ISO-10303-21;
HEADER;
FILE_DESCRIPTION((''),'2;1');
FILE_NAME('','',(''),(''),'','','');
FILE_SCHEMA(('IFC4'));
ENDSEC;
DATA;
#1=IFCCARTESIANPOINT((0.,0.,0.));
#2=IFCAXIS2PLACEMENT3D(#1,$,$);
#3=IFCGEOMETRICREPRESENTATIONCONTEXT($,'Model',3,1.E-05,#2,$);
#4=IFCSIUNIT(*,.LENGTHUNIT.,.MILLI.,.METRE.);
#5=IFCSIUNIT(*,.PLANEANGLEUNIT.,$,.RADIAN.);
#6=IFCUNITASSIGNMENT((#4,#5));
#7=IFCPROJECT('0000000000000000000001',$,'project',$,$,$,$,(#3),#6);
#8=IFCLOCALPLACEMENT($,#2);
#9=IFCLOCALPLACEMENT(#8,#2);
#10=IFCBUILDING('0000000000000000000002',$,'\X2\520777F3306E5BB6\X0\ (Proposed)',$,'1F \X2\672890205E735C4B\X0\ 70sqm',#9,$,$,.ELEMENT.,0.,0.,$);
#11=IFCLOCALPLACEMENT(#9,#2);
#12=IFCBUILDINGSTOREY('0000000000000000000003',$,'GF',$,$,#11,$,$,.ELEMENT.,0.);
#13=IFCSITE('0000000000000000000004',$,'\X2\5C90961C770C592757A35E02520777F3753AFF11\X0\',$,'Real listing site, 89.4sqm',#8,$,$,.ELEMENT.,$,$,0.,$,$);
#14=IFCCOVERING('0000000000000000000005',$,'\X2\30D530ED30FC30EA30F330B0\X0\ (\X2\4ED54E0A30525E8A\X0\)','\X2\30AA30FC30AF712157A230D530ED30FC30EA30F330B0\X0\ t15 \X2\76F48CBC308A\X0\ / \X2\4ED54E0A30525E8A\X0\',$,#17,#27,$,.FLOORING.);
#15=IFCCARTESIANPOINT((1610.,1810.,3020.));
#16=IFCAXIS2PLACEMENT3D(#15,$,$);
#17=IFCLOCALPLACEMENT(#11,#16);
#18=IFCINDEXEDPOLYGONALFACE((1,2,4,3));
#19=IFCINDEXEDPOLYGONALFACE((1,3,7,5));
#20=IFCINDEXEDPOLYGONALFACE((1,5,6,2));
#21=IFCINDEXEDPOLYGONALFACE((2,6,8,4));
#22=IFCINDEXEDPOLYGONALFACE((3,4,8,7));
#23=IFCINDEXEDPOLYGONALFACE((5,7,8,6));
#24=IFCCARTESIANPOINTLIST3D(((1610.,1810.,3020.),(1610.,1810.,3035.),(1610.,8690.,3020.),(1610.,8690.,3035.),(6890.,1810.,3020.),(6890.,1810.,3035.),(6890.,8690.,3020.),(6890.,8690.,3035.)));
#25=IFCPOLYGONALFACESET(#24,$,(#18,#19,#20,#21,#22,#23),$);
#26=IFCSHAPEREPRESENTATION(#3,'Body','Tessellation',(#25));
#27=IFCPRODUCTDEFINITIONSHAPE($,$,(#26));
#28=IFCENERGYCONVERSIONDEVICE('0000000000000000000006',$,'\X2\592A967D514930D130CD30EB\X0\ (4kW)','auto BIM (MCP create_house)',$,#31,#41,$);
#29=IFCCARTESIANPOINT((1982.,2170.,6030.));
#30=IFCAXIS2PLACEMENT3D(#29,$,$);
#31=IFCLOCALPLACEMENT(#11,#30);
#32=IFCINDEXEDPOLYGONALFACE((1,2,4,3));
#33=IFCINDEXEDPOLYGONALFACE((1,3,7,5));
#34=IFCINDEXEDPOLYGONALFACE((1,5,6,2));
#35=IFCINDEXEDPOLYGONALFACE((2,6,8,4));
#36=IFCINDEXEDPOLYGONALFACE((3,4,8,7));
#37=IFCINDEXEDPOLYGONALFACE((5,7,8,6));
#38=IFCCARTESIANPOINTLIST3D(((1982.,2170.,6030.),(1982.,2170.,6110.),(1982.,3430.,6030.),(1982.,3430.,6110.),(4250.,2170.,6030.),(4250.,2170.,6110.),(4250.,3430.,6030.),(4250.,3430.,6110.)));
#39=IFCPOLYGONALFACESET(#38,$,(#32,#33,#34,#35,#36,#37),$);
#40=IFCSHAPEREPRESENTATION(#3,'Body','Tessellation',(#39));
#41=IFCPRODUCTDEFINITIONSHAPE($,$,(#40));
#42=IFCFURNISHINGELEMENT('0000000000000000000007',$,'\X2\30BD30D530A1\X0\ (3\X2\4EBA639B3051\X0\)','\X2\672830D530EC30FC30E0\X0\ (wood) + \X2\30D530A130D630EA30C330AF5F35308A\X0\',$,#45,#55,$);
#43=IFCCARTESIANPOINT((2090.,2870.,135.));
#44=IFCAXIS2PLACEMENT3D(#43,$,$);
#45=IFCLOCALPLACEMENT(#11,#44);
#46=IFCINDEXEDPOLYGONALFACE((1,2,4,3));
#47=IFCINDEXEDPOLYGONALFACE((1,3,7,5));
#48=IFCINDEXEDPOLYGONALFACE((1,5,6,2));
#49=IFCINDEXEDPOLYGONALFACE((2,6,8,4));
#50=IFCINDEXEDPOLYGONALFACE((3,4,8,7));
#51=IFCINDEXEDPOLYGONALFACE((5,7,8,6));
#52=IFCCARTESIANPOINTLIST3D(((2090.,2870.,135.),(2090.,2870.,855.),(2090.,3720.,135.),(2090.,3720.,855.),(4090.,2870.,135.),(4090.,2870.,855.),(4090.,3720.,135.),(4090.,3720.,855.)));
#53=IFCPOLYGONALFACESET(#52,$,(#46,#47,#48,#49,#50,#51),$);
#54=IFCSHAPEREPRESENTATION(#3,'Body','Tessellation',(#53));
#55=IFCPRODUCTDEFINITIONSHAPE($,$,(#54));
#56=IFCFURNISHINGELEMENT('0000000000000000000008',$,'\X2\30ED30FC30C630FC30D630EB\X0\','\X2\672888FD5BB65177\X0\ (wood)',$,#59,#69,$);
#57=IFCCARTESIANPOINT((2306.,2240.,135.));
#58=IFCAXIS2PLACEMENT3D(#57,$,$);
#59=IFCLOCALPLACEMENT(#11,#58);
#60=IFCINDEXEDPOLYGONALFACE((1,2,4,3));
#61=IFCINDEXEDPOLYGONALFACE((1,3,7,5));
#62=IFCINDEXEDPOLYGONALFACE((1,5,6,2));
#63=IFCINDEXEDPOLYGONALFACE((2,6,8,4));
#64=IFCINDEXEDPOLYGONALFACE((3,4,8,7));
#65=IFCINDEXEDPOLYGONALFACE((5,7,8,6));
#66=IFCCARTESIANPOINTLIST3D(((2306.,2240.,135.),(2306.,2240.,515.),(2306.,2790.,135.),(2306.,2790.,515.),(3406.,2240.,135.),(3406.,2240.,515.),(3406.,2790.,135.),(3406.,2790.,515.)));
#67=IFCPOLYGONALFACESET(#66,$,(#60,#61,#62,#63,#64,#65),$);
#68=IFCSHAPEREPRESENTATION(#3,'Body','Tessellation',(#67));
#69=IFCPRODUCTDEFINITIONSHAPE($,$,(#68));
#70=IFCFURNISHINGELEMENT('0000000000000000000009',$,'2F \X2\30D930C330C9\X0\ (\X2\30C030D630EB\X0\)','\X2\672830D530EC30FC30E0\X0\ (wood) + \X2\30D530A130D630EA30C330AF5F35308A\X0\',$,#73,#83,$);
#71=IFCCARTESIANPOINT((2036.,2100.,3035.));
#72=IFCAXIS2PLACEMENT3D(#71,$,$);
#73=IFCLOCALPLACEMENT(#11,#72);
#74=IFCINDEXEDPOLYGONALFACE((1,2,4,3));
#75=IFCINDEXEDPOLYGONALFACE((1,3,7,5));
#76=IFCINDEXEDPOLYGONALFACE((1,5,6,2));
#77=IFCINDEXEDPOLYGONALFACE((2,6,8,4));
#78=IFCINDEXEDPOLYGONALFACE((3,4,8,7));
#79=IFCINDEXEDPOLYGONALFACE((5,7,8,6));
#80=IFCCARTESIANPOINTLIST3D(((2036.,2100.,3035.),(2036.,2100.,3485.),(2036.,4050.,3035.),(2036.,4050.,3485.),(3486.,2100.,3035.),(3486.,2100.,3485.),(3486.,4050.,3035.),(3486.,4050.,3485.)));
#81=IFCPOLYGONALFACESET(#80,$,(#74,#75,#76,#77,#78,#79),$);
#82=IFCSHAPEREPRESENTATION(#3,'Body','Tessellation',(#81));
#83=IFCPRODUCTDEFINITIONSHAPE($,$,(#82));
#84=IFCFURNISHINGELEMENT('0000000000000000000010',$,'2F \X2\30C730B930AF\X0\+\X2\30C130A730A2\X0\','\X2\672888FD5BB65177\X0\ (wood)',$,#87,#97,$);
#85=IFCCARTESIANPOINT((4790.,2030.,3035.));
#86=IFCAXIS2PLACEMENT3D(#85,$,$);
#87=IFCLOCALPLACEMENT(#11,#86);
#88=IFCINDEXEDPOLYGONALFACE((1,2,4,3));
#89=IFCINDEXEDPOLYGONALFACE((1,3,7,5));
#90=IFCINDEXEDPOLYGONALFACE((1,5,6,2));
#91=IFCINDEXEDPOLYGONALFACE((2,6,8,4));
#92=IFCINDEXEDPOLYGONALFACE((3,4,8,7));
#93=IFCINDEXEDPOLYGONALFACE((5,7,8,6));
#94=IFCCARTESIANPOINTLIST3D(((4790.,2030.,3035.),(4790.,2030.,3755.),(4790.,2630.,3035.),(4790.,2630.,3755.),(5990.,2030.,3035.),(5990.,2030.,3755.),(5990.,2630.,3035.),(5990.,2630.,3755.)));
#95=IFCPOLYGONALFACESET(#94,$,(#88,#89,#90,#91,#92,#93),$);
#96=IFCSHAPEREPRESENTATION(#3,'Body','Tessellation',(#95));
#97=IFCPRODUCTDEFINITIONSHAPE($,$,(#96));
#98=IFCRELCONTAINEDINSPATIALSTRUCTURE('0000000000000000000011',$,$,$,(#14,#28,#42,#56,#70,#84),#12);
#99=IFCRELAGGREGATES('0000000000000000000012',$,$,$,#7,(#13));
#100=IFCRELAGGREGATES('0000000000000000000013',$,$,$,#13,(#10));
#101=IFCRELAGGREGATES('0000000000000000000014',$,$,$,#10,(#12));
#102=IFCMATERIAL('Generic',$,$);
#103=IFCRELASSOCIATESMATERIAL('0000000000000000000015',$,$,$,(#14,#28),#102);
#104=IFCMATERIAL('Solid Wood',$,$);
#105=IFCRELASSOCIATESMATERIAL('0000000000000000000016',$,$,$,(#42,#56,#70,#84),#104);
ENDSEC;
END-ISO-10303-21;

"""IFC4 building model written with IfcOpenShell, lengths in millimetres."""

from ifc_helpers import new_model, si_unit, frame, frame_2d, origin, place, context, project, spatial, rectangle, extrude, material, element, save


model = new_model("IFC4")

# Units and contexts
model_context = context("Model", 3, precision=1e-05, world=origin())
ifc_project = project(units=[si_unit("LENGTHUNIT", "METRE", prefix="MILLI"), si_unit("PLANEANGLEUNIT", "RADIAN")], contexts=[model_context])

# Site, building, storey
site_placement = place(None, origin())
site = spatial("IfcSite", under=ifc_project, at=site_placement, Name="岐阜県大垣市切石町１", ObjectType="Real listing site, 89.4sqm", CompositionType="ELEMENT", RefElevation=0.0)
building_placement = place(site_placement, origin())
building = spatial("IfcBuilding", under=site, at=building_placement, Name="切石の家 (Proposed)", ObjectType="1F 木造平屋 70sqm", CompositionType="ELEMENT", ElevationOfRefHeight=0.0, ElevationOfTerrain=0.0)
storey_placement = place(building_placement, origin())
storey = spatial("IfcBuildingStorey", under=building, at=storey_placement, Name="GF", CompositionType="ELEMENT", Elevation=0.0)

# Shared definitions
ifc_material_1 = material(Name="Solid Wood")

# Shared definitions
ifc_material_2 = material(Name="Generic")

# Covering
covering_placement = place(storey_placement, frame((1610.0, 1810.0, 3020.0)))
element("IfcCovering", 1, at=covering_placement, inside=storey, material=ifc_material_2, Name="フローリング (仕上げ床)", Description="オーク無垢フローリング t15 直貼り / 仕上げ床", PredefinedType="FLOORING", context=model_context, shape_type="SweptSolid", body=[
    extrude(rectangle(XDim=5280.0, YDim=6880.0, at=frame_2d((2640.0, 3440.0))), frame((1610.0, 1810.0, 3020.0)), (0.0, 0.0, 1.0), 15.0),
])

# Energy conversion device
energy_conversion_device_placement = place(storey_placement, frame((1982.0, 2170.0, 6030.0)))
element("IfcEnergyConversionDevice", 2, at=energy_conversion_device_placement, inside=storey, material=ifc_material_2, Name="太陽光パネル (4kW)", Description="auto BIM (MCP create_house)", context=model_context, shape_type="SweptSolid", body=[
    extrude(rectangle(XDim=2268.0, YDim=1260.0, at=frame_2d((1134.0, 630.0))), frame((1982.0, 2170.0, 6030.0)), (0.0, 0.0, 1.0), 80.0),
])

# Furnishing elements
furnishing_1_placement = place(storey_placement, frame((2090.0, 2870.0, 135.0)))
element("IfcFurnishingElement", 3, at=furnishing_1_placement, inside=storey, material=ifc_material_1, Name="ソファ (3人掛け)", Description="木フレーム (wood) + ファブリック張り", context=model_context, shape_type="SweptSolid", body=[
    extrude(rectangle(XDim=2000.0, YDim=850.0, at=frame_2d((1000.0, 425.0))), frame((2090.0, 2870.0, 135.0)), (0.0, 0.0, 1.0), 720.0),
])
furnishing_2_placement = place(storey_placement, frame((2306.0, 2240.0, 135.0)))
element("IfcFurnishingElement", 4, at=furnishing_2_placement, inside=storey, material=ifc_material_1, Name="ローテーブル", Description="木製家具 (wood)", context=model_context, shape_type="SweptSolid", body=[
    extrude(rectangle(XDim=1100.0, YDim=550.0, at=frame_2d((550.0, 275.0))), frame((2306.0, 2240.0, 135.0)), (0.0, 0.0, 1.0), 380.0),
])
furnishing_3_placement = place(storey_placement, frame((2036.0, 2100.0, 3035.0)))
element("IfcFurnishingElement", 5, at=furnishing_3_placement, inside=storey, material=ifc_material_1, Name="2F ベッド (ダブル)", Description="木フレーム (wood) + ファブリック張り", context=model_context, shape_type="SweptSolid", body=[
    extrude(rectangle(XDim=1450.0, YDim=1950.0, at=frame_2d((725.0, 975.0))), frame((2036.0, 2100.0, 3035.0)), (0.0, 0.0, 1.0), 450.0),
])
furnishing_4_placement = place(storey_placement, frame((4790.0, 2030.0, 3035.0)))
element("IfcFurnishingElement", 6, at=furnishing_4_placement, inside=storey, material=ifc_material_1, Name="2F デスク+チェア", Description="木製家具 (wood)", context=model_context, shape_type="SweptSolid", body=[
    extrude(rectangle(XDim=1200.0, YDim=600.0, at=frame_2d((600.0, 300.0))), frame((4790.0, 2030.0, 3035.0)), (0.0, 0.0, 1.0), 720.0),
])

save(model, "model.ifc")
